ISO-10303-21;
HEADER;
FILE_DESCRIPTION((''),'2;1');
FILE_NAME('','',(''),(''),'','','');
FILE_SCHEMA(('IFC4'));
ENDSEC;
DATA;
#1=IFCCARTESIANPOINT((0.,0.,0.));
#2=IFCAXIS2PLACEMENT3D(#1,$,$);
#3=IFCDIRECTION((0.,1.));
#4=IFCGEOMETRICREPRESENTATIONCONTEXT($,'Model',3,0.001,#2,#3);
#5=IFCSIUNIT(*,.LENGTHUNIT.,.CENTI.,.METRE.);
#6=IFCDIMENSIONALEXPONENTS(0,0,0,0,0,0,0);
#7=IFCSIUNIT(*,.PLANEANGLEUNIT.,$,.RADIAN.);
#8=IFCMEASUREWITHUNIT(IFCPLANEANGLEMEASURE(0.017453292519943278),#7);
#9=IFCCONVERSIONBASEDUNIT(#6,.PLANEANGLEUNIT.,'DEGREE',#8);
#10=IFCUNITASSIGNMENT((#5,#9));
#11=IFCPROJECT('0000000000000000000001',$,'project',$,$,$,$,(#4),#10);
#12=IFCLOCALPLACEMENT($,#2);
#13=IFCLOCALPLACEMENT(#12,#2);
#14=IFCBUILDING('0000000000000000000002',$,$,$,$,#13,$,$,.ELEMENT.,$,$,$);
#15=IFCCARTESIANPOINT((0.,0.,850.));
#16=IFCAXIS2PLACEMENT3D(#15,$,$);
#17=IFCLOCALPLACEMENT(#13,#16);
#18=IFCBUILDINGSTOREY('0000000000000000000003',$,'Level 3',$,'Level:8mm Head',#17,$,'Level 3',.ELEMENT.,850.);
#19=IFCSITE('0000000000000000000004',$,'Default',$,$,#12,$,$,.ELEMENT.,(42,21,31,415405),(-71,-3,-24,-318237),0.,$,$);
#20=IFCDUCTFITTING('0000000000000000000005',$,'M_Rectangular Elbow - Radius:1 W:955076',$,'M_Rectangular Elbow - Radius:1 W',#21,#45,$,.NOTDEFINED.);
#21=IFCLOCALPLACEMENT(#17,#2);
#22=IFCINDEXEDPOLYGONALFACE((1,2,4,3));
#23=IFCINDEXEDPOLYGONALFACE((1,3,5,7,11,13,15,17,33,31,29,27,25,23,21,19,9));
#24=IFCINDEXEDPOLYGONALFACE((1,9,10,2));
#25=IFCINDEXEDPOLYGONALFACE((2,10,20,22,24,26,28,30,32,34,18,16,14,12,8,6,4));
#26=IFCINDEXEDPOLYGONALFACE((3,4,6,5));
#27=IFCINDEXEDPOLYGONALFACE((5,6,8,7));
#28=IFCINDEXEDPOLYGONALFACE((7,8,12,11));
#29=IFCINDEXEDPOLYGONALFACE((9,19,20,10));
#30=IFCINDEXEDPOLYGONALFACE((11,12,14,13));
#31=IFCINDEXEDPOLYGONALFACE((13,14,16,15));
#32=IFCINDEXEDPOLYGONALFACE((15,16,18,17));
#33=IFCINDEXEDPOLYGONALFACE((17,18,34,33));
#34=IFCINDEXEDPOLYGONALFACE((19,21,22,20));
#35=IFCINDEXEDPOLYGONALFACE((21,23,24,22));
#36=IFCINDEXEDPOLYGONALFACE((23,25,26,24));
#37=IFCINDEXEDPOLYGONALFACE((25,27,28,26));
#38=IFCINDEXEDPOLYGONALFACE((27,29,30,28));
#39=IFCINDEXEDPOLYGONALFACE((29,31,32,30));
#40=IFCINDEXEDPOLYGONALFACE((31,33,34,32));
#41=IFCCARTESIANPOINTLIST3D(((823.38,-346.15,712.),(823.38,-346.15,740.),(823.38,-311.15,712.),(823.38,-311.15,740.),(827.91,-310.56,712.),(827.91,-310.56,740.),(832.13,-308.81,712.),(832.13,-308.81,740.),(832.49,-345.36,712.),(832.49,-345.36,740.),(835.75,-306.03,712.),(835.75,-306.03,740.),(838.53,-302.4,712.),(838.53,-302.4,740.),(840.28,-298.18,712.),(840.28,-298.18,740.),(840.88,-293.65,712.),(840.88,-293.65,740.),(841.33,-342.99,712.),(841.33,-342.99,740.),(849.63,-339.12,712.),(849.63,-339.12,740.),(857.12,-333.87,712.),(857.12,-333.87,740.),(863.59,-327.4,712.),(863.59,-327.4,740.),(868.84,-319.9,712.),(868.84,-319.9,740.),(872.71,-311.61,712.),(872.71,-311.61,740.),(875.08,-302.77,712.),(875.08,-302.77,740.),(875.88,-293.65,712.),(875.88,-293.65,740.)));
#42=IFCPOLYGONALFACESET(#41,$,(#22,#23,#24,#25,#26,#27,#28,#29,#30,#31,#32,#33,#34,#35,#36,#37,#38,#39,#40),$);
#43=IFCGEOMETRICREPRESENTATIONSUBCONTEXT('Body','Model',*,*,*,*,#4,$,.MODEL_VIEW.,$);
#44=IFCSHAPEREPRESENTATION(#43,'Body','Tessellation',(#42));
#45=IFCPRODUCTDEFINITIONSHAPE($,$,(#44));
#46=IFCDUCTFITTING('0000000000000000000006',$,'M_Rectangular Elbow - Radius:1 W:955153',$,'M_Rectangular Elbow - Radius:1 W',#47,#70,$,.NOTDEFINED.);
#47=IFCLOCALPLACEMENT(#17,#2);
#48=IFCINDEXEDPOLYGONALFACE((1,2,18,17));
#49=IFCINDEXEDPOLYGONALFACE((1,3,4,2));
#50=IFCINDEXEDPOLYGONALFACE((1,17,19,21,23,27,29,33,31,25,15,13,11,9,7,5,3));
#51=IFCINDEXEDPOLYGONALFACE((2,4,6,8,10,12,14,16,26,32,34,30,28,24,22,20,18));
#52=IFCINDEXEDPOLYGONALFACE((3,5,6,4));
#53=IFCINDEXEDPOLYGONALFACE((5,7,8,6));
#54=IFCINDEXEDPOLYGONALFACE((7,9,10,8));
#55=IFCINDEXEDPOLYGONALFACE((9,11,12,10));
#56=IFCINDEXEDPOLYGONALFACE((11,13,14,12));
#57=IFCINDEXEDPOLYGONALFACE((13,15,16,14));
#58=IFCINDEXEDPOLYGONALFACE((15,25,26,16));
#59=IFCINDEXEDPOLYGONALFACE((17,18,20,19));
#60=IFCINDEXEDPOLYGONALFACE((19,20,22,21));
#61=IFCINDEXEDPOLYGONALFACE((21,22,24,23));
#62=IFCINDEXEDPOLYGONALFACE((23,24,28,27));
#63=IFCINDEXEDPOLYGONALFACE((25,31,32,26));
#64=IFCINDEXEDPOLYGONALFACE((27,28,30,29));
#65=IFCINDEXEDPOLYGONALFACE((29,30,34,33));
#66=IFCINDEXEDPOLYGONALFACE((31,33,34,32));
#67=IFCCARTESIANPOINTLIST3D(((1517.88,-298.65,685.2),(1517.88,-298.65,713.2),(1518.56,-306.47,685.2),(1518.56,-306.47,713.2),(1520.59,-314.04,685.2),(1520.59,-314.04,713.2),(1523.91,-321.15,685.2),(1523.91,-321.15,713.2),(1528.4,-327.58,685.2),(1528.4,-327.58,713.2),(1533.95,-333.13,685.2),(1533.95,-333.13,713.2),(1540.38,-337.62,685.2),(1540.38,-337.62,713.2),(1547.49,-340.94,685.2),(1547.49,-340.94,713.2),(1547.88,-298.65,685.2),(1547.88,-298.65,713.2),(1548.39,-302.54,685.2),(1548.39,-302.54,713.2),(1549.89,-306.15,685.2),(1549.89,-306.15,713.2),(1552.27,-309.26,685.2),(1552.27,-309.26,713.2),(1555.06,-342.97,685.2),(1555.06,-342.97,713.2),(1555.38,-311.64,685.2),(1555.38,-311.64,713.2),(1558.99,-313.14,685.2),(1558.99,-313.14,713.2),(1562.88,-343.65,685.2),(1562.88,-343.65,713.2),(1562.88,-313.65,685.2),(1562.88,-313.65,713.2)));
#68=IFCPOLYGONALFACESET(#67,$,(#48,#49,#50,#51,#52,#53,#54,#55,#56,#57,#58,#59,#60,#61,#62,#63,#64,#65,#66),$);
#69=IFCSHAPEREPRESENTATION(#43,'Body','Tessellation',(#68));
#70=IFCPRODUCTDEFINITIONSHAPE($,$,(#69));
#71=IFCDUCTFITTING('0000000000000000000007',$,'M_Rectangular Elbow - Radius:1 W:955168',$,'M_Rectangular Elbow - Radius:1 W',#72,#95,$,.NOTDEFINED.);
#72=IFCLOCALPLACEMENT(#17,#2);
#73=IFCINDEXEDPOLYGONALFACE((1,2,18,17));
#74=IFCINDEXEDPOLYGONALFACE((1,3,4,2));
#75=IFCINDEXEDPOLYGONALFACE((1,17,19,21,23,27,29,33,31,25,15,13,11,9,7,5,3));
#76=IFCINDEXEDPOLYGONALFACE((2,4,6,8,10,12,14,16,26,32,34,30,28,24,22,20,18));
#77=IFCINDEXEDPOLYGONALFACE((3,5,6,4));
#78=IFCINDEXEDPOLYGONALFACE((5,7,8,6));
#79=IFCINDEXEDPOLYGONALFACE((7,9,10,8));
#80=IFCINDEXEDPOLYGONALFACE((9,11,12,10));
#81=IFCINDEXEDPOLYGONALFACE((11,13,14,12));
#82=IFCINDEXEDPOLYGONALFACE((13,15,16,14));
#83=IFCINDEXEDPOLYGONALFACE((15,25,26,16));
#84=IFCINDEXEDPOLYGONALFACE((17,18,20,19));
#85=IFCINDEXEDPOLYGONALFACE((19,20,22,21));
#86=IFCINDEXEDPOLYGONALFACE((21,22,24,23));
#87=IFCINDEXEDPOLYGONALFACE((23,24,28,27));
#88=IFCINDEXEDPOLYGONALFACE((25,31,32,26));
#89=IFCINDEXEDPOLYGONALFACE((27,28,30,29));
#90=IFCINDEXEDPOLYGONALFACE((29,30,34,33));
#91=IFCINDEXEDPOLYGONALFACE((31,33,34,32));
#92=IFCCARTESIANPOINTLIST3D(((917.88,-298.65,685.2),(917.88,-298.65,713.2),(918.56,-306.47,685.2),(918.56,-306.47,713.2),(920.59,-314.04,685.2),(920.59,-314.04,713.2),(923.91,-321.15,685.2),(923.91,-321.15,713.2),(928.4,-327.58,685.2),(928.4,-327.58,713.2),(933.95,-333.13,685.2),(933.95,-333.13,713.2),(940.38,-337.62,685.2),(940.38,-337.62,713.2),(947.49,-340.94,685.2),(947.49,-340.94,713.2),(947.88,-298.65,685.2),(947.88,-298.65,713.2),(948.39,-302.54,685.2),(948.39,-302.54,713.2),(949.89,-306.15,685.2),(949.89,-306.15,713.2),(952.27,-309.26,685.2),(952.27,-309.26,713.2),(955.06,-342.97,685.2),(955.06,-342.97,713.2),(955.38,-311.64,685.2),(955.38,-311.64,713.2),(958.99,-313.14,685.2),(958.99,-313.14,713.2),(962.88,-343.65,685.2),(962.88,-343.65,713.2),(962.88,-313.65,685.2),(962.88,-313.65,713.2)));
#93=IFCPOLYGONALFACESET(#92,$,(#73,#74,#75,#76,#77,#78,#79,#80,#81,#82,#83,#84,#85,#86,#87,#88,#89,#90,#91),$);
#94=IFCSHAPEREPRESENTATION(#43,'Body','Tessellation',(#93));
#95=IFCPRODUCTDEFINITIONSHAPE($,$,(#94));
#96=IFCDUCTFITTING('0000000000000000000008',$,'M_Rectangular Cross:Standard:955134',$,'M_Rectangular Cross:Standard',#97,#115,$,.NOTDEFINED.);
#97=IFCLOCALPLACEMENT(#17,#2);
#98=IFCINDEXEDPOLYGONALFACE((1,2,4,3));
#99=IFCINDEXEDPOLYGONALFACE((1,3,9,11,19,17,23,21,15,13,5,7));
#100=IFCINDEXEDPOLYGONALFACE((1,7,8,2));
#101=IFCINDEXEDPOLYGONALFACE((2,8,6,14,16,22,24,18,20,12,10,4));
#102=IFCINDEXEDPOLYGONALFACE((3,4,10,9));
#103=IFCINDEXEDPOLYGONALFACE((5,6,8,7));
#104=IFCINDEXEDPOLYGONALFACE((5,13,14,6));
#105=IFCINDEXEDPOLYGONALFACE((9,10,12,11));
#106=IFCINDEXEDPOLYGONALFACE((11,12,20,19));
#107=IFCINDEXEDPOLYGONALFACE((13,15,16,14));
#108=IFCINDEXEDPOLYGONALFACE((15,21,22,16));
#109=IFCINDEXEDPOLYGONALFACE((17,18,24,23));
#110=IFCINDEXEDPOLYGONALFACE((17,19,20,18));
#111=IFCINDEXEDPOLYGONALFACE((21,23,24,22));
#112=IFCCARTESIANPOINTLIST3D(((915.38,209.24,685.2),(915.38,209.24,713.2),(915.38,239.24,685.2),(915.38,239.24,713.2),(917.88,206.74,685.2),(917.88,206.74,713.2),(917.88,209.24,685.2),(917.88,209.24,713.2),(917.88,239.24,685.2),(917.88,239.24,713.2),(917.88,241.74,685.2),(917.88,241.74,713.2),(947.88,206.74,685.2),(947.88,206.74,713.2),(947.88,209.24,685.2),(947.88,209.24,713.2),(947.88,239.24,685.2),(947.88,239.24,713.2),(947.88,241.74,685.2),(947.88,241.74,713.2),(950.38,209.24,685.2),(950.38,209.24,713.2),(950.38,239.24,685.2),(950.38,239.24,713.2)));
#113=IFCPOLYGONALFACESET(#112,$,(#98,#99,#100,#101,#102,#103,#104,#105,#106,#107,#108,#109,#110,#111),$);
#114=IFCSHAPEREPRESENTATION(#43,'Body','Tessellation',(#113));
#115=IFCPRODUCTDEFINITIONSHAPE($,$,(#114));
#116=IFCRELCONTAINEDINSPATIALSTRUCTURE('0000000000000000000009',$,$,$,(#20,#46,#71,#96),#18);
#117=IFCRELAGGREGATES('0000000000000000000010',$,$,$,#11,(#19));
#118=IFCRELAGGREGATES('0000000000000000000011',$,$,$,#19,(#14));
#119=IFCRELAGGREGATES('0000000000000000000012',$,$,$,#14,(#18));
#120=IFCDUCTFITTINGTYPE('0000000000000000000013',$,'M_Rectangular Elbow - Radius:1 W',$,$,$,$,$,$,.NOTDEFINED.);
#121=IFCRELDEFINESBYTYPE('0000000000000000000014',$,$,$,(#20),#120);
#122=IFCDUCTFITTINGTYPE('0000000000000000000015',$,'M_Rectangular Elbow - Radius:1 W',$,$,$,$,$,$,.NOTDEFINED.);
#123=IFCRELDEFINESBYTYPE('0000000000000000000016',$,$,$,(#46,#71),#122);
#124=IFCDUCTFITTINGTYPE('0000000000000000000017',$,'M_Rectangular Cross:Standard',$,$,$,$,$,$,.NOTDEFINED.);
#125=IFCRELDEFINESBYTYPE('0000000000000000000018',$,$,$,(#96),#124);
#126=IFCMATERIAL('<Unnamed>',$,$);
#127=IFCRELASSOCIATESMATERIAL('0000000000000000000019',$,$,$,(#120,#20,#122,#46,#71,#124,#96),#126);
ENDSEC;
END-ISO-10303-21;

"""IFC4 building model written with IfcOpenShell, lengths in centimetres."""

from ifc_helpers import new_model, entity, si_unit, converted_unit, direction, frame, origin, place, context, subcontext, project, spatial, line, arc, indexed_curve, outline, extrude, source, transform, mapped, material, type_object, type_shapes, element, save


model = new_model("IFC4")

# Units and contexts
model_context = context("Model", 3, precision=0.001, world=origin(), true_north=direction((0.0, 1.0)))
body_context = subcontext(model_context, "Body", "Model", "MODEL_VIEW")
ifc_project = project(units=[si_unit("LENGTHUNIT", "METRE", prefix="CENTI"), converted_unit("PLANEANGLEUNIT", "DEGREE", entity("IfcPlaneAngleMeasure", 0.017453292519943278), si_unit("PLANEANGLEUNIT", "RADIAN"), dimensions=[0, 0, 0, 0, 0, 0, 0])], contexts=[model_context])

# Site, building, storey
site_placement = place(None, origin())
site = spatial("IfcSite", under=ifc_project, at=site_placement, Name="Default", CompositionType="ELEMENT", RefLatitude=(42, 21, 31, 415405), RefLongitude=(-71, -3, -24, -318237), RefElevation=0.0)
building_placement = place(site_placement, origin())
building = spatial("IfcBuilding", under=site, at=building_placement, CompositionType="ELEMENT")
storey_placement = place(building_placement, frame((0.0, 0.0, 850.0)))
storey = spatial("IfcBuildingStorey", under=building, at=storey_placement, Name="Level 3", ObjectType="Level:8mm Head", LongName="Level 3", CompositionType="ELEMENT", Elevation=850.0)

# Duct fittings
ifc_material = material(Name="<Unnamed>")
duct_fitting_type_1 = type_object("IfcDuctFittingType", Name="M_Rectangular Elbow - Radius:1 W", PredefinedType="NOTDEFINED", material=ifc_material)
shared_shape_1 = source(origin(), body_context, "Body", "SweptSolid", [
    extrude(outline(indexed_curve([(-17.5, -35.0), (19.62, -19.62), (35.0, 17.5), (0.0, 17.5), (-5.13, 5.13), (-17.5, 0.0)], segments=[arc(1, 2, 3), line(3, 4), arc(4, 5, 6), line(6, 1)], self_intersect=False)), frame((-17.5, -17.5, -14.0), z_axis=(0.0, 0.0, 1.0), x_axis=(0.0, 1.0, 0.0)), (0.0, 0.0, 1.0), 28.0),
])
type_shapes(duct_fitting_type_1, [shared_shape_1])
duct_fitting_1_placement = place(storey_placement, frame((858.38, -328.65, 726.0), z_axis=(0.0, 0.0, 1.0), x_axis=(0.0, -1.0, 0.0)))
element("IfcDuctFitting", 1, at=duct_fitting_1_placement, inside=storey, type_object=duct_fitting_type_1, material=ifc_material, Name="M_Rectangular Elbow - Radius:1 W:955076", ObjectType="M_Rectangular Elbow - Radius:1 W", PredefinedType="NOTDEFINED", context=body_context, shape_type="MappedRepresentation", body=[
    mapped(shared_shape_1, transform((0.0, 0.0, 0.0), scale=1.0)),
])
duct_fitting_type_2 = type_object("IfcDuctFittingType", Name="M_Rectangular Elbow - Radius:1 W", PredefinedType="NOTDEFINED", material=ifc_material)
shared_shape_2 = source(origin(), body_context, "Body", "SweptSolid", [
    extrude(outline(indexed_curve([(-15.0, -30.0), (16.82, -16.82), (30.0, 15.0), (0.0, 15.0), (-4.39, 4.39), (-15.0, 0.0)], segments=[arc(1, 2, 3), line(3, 4), arc(4, 5, 6), line(6, 1)], self_intersect=False)), frame((-15.0, -15.0, -14.0), z_axis=(0.0, 0.0, 1.0), x_axis=(0.0, 1.0, 0.0)), (0.0, 0.0, 1.0), 28.0),
])
type_shapes(duct_fitting_type_2, [shared_shape_2])
for number, where, z_axis, x_axis, name in (
    (2, (1532.88, -328.65, 699.2), (0.0, 0.0, 1.0), (-1.0, 0.0, 0.0), "M_Rectangular Elbow - Radius:1 W:955153"),
    (3, (932.88, -328.65, 699.2), (0.0, 0.0, 1.0), (-1.0, 0.0, 0.0), "M_Rectangular Elbow - Radius:1 W:955168"),
):
    element("IfcDuctFitting", number, at=place(storey_placement, frame(where, z_axis=z_axis, x_axis=x_axis)), inside=storey, type_object=duct_fitting_type_2, material=ifc_material, Name=name, ObjectType="M_Rectangular Elbow - Radius:1 W", PredefinedType="NOTDEFINED", context=body_context, shape_type="MappedRepresentation", body=[
        mapped(shared_shape_2, transform((0.0, 0.0, 0.0), scale=1.0)),
    ])
duct_fitting_type_3 = type_object("IfcDuctFittingType", Name="M_Rectangular Cross:Standard", PredefinedType="NOTDEFINED", material=ifc_material)
shared_shape_3 = source(origin(), body_context, "Body", "SweptSolid", [
    extrude(outline(indexed_curve([(-15.0, -17.5), (15.0, -17.5), (15.0, -15.0), (17.5, -15.0), (17.5, 15.0), (15.0, 15.0), (15.0, 17.5), (-15.0, 17.5), (-15.0, 15.0), (-17.5, 15.0), (-17.5, -15.0), (-15.0, -15.0), (-15.0, -17.5)], self_intersect=False)), frame((0.0, 0.0, -14.0), z_axis=(0.0, 0.0, 1.0), x_axis=(-1.0, 0.0, 0.0)), (0.0, 0.0, 1.0), 28.0),
])
type_shapes(duct_fitting_type_3, [shared_shape_3])
duct_fitting_2_placement = place(storey_placement, frame((932.88, 224.24, 699.2), z_axis=(0.0, 0.0, 1.0), x_axis=(-1.0, 0.0, 0.0)))
element("IfcDuctFitting", 4, at=duct_fitting_2_placement, inside=storey, type_object=duct_fitting_type_3, material=ifc_material, Name="M_Rectangular Cross:Standard:955134", ObjectType="M_Rectangular Cross:Standard", PredefinedType="NOTDEFINED", context=body_context, shape_type="MappedRepresentation", body=[
    mapped(shared_shape_3, transform((0.0, 0.0, 0.0), scale=1.0)),
])

save(model, "model.ifc")
